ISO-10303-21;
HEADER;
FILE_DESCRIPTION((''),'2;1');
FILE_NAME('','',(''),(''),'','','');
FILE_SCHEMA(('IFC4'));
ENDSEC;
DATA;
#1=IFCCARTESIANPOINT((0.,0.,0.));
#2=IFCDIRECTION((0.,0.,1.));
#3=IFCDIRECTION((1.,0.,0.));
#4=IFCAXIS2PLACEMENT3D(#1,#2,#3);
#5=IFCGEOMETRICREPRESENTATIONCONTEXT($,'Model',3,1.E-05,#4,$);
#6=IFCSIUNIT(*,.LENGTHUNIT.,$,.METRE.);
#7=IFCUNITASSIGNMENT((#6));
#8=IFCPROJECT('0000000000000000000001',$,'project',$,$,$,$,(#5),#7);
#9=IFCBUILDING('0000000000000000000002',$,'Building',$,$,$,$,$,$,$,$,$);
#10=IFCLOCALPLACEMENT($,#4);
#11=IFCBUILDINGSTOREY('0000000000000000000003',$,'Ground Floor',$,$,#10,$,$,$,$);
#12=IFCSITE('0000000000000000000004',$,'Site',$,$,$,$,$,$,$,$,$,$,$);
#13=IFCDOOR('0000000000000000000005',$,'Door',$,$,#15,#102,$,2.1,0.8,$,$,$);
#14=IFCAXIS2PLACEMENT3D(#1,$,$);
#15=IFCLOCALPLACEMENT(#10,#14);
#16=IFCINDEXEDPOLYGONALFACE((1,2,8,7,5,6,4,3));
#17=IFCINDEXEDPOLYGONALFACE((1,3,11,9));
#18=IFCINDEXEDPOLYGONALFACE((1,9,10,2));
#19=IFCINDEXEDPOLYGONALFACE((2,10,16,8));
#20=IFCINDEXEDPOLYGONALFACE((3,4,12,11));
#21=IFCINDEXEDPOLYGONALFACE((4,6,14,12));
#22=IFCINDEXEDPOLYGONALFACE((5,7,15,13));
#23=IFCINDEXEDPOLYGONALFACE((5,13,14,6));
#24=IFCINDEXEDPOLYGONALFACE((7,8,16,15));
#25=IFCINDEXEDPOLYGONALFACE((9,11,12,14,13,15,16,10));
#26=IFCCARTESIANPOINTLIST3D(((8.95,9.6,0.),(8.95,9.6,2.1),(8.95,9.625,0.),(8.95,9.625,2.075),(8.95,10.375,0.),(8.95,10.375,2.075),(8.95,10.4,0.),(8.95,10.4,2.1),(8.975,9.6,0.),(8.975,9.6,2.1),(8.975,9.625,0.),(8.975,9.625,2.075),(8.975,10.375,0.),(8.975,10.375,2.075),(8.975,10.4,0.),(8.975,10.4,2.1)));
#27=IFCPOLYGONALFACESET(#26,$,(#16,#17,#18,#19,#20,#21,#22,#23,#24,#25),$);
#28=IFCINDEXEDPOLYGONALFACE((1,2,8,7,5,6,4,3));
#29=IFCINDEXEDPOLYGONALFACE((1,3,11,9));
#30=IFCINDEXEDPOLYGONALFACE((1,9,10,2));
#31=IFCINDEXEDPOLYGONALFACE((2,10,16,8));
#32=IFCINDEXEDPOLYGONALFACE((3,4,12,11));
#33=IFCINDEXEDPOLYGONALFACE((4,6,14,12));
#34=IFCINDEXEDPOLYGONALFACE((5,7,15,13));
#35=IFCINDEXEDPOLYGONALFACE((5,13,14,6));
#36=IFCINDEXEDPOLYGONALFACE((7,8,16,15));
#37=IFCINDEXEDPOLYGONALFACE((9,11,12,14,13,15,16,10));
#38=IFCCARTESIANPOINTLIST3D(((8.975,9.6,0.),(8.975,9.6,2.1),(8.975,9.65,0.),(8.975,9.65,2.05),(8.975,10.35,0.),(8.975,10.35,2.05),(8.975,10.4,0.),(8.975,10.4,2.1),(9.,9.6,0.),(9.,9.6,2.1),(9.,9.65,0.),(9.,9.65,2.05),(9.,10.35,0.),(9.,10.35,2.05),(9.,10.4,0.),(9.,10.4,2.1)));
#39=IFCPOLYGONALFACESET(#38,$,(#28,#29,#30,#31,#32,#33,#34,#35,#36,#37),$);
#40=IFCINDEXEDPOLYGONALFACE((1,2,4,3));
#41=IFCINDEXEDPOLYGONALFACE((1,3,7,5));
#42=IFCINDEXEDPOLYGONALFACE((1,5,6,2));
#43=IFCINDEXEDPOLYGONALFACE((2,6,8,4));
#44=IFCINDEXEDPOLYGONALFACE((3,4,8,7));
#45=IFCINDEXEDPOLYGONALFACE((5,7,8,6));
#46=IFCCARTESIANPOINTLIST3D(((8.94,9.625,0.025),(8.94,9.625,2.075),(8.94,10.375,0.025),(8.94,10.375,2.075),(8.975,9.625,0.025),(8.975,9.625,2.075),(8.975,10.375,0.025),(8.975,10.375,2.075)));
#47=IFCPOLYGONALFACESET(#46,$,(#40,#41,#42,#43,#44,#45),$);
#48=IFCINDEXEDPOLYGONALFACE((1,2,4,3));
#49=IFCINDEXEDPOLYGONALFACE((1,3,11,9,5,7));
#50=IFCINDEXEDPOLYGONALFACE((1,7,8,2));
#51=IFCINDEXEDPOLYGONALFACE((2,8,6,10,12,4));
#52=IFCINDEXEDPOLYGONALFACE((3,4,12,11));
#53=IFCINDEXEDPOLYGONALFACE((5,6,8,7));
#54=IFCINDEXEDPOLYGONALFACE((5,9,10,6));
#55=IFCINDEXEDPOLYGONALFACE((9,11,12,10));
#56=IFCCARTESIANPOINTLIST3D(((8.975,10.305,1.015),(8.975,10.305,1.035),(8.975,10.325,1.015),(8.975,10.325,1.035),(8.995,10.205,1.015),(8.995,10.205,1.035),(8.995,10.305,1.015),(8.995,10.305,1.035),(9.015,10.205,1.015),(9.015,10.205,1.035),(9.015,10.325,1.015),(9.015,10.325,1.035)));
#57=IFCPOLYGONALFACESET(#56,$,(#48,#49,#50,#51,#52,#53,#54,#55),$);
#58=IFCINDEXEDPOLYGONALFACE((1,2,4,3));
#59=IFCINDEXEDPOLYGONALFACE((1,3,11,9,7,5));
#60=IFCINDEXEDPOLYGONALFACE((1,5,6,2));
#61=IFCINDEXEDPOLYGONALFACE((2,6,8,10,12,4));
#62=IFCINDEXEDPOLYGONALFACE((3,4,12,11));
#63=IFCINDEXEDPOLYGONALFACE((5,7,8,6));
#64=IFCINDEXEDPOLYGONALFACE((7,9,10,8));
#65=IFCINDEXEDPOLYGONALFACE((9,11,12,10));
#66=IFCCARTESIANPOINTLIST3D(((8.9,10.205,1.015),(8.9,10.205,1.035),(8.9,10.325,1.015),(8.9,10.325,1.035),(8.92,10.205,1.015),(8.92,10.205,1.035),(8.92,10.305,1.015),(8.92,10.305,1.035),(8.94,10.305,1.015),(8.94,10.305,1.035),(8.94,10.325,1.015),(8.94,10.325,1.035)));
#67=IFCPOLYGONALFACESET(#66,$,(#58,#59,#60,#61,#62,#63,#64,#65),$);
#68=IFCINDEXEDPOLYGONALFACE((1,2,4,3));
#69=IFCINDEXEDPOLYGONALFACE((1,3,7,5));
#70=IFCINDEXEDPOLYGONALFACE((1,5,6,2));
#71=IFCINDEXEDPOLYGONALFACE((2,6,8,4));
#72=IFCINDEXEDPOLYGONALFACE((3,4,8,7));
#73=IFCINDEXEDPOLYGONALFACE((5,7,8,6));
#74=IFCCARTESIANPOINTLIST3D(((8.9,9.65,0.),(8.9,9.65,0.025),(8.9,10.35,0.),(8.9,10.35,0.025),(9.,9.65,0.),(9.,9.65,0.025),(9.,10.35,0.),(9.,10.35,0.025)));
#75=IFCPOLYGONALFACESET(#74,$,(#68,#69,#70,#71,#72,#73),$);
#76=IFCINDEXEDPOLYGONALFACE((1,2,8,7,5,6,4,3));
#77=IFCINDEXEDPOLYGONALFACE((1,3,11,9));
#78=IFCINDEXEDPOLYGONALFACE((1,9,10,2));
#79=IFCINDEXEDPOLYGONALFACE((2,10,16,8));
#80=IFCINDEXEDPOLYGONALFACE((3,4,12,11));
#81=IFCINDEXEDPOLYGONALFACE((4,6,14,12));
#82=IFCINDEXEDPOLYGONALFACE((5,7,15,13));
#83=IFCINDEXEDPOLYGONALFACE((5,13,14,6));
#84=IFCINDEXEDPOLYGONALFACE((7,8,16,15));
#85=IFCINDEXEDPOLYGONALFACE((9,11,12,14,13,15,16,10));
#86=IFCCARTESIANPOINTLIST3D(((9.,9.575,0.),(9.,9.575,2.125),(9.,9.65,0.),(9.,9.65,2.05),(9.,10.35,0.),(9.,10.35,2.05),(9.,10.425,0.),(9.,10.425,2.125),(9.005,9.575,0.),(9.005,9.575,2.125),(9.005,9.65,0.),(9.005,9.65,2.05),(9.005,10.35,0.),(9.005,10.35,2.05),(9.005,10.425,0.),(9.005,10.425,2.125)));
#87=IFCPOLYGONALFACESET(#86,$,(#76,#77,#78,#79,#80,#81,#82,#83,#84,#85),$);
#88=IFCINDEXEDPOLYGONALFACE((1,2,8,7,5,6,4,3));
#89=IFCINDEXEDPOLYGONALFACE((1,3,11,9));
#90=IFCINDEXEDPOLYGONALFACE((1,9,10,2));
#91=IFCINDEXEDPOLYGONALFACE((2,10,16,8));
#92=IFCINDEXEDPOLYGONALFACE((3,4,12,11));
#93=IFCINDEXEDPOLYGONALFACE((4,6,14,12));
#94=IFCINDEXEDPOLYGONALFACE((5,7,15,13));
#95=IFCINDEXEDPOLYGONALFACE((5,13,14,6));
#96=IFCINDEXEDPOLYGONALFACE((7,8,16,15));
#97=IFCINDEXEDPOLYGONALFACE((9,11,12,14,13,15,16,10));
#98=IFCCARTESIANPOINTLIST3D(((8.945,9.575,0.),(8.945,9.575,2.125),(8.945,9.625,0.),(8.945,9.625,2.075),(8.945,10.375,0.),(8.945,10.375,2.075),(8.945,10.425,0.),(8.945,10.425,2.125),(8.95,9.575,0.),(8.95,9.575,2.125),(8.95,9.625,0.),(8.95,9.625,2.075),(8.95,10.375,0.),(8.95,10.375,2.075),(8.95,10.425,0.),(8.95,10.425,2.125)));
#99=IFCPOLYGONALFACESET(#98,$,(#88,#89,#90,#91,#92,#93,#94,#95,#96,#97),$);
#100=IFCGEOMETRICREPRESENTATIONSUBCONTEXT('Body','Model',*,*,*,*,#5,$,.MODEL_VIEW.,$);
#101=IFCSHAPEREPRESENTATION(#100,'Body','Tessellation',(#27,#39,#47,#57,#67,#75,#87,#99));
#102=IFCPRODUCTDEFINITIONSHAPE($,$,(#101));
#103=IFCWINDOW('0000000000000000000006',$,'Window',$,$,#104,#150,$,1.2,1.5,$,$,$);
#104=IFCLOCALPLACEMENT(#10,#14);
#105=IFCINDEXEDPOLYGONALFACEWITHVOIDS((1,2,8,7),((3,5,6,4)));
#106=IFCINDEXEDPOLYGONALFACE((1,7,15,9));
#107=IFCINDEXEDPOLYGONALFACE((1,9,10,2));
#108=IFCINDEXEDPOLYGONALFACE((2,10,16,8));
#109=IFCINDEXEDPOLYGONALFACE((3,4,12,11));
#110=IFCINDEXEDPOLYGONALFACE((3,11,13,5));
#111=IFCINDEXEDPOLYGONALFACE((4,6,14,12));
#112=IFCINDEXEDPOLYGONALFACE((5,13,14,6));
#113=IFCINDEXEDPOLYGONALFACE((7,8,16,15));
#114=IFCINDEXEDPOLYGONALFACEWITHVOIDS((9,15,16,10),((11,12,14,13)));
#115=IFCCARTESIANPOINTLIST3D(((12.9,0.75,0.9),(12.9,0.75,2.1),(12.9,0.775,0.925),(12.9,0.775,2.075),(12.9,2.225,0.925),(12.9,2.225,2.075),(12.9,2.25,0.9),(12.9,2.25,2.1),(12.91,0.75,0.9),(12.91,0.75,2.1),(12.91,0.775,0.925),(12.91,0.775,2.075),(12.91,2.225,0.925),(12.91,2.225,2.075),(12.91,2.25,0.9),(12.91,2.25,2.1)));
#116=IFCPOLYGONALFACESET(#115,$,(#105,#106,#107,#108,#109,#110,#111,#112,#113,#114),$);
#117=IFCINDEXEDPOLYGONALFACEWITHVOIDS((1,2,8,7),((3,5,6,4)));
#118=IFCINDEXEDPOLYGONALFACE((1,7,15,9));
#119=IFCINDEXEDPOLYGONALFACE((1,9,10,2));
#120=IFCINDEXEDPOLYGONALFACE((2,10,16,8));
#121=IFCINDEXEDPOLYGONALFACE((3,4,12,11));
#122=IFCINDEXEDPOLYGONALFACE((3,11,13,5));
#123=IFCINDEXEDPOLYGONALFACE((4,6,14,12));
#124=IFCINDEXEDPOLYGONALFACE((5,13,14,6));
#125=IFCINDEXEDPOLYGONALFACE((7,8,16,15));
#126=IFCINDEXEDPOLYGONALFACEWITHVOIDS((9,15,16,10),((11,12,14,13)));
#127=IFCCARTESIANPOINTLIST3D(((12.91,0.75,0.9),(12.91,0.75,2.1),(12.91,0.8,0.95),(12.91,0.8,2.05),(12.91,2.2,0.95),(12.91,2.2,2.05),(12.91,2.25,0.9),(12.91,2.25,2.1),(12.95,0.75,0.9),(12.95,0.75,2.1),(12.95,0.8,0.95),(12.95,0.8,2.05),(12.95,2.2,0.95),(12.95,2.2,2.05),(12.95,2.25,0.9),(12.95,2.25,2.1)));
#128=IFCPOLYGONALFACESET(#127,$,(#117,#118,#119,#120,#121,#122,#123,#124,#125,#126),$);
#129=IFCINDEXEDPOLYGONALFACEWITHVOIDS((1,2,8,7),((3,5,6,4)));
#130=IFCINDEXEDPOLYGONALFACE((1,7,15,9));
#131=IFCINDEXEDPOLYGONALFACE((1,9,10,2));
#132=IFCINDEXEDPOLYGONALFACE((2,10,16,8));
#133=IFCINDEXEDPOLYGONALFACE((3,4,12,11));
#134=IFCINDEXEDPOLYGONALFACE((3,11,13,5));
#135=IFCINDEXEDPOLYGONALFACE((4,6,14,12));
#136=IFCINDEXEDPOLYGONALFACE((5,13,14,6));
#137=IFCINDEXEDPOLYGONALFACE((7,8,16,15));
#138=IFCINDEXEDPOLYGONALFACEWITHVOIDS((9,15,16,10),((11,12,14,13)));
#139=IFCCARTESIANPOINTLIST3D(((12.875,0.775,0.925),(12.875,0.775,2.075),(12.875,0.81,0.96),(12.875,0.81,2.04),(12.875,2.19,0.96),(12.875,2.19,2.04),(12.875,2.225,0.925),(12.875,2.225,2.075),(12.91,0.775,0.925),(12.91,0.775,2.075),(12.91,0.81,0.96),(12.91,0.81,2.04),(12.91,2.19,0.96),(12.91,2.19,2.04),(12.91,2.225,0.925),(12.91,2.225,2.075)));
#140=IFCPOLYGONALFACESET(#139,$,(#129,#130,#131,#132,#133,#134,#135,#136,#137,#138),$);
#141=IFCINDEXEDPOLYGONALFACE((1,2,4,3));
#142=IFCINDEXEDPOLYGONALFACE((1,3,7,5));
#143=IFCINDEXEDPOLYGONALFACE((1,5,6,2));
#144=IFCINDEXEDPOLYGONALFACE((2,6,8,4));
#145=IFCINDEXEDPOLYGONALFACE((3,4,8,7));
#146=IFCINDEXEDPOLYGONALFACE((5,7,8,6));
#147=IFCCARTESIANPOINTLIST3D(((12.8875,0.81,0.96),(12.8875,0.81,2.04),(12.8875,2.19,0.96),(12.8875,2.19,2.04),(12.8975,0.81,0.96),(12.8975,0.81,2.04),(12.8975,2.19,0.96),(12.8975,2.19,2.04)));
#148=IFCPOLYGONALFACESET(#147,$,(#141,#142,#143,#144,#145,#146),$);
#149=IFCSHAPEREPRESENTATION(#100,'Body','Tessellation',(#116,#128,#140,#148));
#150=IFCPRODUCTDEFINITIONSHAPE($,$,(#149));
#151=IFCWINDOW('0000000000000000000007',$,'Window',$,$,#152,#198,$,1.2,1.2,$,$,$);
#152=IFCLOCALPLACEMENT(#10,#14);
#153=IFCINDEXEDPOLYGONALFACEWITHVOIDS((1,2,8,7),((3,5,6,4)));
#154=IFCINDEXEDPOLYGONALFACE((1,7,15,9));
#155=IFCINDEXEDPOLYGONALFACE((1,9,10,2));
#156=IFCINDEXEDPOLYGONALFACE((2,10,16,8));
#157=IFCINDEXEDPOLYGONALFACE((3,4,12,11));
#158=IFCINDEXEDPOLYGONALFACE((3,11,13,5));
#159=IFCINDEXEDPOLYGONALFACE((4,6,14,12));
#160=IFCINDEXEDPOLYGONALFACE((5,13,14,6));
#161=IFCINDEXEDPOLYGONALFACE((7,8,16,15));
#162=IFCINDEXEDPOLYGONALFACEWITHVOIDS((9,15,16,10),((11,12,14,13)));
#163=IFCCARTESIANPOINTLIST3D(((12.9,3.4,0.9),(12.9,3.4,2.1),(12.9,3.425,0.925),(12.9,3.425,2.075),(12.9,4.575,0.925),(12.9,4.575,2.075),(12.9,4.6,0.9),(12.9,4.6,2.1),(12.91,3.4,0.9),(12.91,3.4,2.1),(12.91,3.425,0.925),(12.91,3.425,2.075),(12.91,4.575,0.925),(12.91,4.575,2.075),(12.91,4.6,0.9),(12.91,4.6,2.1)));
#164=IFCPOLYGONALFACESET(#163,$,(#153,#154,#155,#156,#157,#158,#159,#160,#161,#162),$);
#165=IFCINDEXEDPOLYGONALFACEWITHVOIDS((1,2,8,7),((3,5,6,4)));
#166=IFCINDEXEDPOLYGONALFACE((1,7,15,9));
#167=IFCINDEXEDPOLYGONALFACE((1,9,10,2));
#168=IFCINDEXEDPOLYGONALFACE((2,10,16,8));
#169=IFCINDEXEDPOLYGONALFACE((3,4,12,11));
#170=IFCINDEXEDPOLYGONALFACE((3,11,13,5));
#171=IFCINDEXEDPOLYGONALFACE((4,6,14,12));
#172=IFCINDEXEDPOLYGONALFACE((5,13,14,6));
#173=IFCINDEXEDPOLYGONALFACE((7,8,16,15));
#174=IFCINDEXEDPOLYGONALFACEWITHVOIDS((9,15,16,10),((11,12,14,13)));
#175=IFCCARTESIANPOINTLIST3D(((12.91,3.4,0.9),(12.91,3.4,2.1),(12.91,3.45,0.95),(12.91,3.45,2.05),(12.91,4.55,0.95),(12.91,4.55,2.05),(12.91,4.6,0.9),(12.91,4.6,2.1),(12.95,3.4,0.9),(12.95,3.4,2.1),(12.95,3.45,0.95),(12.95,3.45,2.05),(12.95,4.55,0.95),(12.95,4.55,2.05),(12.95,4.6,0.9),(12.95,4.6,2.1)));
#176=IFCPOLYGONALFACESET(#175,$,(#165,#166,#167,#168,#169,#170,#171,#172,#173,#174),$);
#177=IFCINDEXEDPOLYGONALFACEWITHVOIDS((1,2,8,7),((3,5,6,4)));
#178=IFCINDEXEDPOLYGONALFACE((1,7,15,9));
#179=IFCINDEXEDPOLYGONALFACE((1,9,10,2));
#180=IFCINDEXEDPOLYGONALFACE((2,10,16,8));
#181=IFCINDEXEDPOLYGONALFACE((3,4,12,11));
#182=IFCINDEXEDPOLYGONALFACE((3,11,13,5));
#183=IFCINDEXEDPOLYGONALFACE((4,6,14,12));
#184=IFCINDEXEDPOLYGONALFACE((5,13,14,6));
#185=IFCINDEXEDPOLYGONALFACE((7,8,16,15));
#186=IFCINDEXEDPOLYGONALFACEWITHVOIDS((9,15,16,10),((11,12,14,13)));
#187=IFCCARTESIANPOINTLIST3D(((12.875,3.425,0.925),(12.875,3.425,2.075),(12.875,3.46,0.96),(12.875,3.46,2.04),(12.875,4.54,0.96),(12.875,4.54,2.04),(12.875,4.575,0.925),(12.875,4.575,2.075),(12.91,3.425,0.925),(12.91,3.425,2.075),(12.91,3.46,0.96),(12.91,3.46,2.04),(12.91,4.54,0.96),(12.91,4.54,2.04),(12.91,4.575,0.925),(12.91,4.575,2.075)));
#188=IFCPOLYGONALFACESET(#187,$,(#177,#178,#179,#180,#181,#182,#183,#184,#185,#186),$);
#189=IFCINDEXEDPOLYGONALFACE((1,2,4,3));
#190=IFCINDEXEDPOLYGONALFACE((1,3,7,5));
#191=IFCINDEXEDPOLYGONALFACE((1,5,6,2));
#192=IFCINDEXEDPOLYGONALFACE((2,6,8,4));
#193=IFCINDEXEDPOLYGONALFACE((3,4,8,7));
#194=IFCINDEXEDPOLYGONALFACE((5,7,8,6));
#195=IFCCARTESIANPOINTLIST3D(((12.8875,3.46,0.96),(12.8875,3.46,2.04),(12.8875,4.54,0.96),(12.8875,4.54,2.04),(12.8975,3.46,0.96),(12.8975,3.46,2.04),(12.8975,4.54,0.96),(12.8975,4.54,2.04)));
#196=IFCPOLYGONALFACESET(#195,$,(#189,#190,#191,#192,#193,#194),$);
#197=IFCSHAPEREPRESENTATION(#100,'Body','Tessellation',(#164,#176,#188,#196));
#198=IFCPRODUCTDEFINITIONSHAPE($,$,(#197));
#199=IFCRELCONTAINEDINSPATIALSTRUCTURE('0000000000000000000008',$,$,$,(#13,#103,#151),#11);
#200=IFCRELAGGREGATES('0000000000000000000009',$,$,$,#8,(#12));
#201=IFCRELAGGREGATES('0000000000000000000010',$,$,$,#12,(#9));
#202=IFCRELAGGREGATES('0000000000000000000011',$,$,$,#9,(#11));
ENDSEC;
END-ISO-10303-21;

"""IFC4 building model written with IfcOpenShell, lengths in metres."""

from ifc_helpers import new_model, si_unit, frame, origin_with_axes, place, context, subcontext, project, spatial, line, indexed_curve, outline, extrude, element, save


model = new_model("IFC4")

# Units and contexts
model_context = context("Model", 3, precision=1e-05, world=origin_with_axes())
body_context = subcontext(model_context, "Body", "Model", "MODEL_VIEW")
ifc_project = project(units=[si_unit("LENGTHUNIT", "METRE")], contexts=[model_context])

# Site, building, storey
site = spatial("IfcSite", under=ifc_project, Name="Site")
building = spatial("IfcBuilding", under=site, Name="Building")
storey_placement = place(None, origin_with_axes())
storey = spatial("IfcBuildingStorey", under=building, at=storey_placement, Name="Ground Floor")

# Door
door_1_placement = place(storey_placement, frame((9.0, 9.6, 0.0), z_axis=(0.0, 0.0, 1.0), x_axis=(0.0, 1.0, 0.0)))
element("IfcDoor", 1, at=door_1_placement, inside=storey, Name="Door", OverallHeight=2.1, OverallWidth=0.8, context=body_context, shape_type="SweptSolid", body=[
    extrude(outline(indexed_curve([(0.0, 0.0), (0.0, 2.1), (0.8, 2.1), (0.8, 0.0), (0.775, 0.0), (0.775, 2.075), (0.025, 2.075), (0.025, 0.0)], segments=[line(1, 2, 3, 4, 5, 6, 7, 8, 1)])), frame((0.0, 0.025, 0.0), z_axis=(0.0, -1.0, 0.0), x_axis=(1.0, 0.0, 0.0)), (0.0, 0.0, -1.0), 0.025),
    extrude(outline(indexed_curve([(0.0, 0.0), (0.0, 2.1), (0.8, 2.1), (0.8, 0.0), (0.75, 0.0), (0.75, 2.05), (0.05, 2.05), (0.05, 0.0)], segments=[line(1, 2, 3, 4, 5, 6, 7, 8, 1)])), frame((0.0, 0.0, 0.0), z_axis=(0.0, -1.0, 0.0), x_axis=(1.0, 0.0, 0.0)), (0.0, 0.0, -1.0), 0.025),
    extrude(outline(indexed_curve([(0.0, 0.0), (0.75, 0.0), (0.75, 0.035), (0.0, 0.035)], segments=[line(1, 2, 3, 4, 1)])), frame((0.025, 0.025, 0.025), z_axis=(0.0, 0.0, 1.0), x_axis=(1.0, 0.0, 0.0)), (0.0, 0.0, 1.0), 2.05),
    extrude(outline(indexed_curve([(0.0, 0.0), (0.0, -0.04), (-0.12, -0.04), (-0.12, -0.02), (-0.02, -0.02), (-0.02, 0.0)], segments=[line(1, 2, 3, 4, 5, 6, 1)])), frame((0.725, 0.025, 1.015), z_axis=(0.0, 0.0, 1.0), x_axis=(1.0, 0.0, 0.0)), (0.0, 0.0, 1.0), 0.02),
    extrude(outline(indexed_curve([(0.0, 0.0), (0.0, 0.04), (-0.12, 0.04), (-0.12, 0.02), (-0.02, 0.02), (-0.02, 0.0)], segments=[line(1, 2, 3, 4, 5, 6, 1)])), frame((0.725, 0.06, 1.015), z_axis=(0.0, 0.0, 1.0), x_axis=(1.0, 0.0, 0.0)), (0.0, 0.0, 1.0), 0.02),
    extrude(outline(indexed_curve([(0.0, 0.0), (0.7, 0.0), (0.7, 0.1), (0.0, 0.1)], segments=[line(1, 2, 3, 4, 1)])), frame((0.05, 0.0, 0.0), z_axis=(0.0, 0.0, 1.0), x_axis=(1.0, 0.0, 0.0)), (0.0, 0.0, 1.0), 0.025),
    extrude(outline(indexed_curve([(0.0, 0.0), (0.0, 2.125), (0.85, 2.125), (0.85, 0.0), (0.775, 0.0), (0.775, 2.05), (0.075, 2.05), (0.075, 0.0)], segments=[line(1, 2, 3, 4, 5, 6, 7, 8, 1)])), frame((-0.025, -0.005, 0.0), z_axis=(0.0, -1.0, 0.0), x_axis=(1.0, 0.0, 0.0)), (0.0, 0.0, -1.0), 0.005),
    extrude(outline(indexed_curve([(0.0, 0.0), (0.0, 2.125), (0.85, 2.125), (0.85, 0.0), (0.8, 0.0), (0.8, 2.075), (0.05, 2.075), (0.05, 0.0)], segments=[line(1, 2, 3, 4, 5, 6, 7, 8, 1)])), frame((-0.025, 0.05, 0.0), z_axis=(0.0, -1.0, 0.0), x_axis=(1.0, 0.0, 0.0)), (0.0, 0.0, -1.0), 0.005),
])

# Windows
window_1_placement = place(storey_placement, frame((13.0, 0.75, 0.9), z_axis=(0.0, 0.0, 1.0), x_axis=(0.0, 1.0, 0.0)))
element("IfcWindow", 2, at=window_1_placement, inside=storey, Name="Window", OverallHeight=1.2, OverallWidth=1.5, context=body_context, shape_type="SweptSolid", body=[
    extrude(outline(indexed_curve([(0.0, 0.0), (1.5, 0.0), (1.5, 1.2), (0.0, 1.2)], segments=[line(1, 2, 3, 4, 1)]), holes=[indexed_curve([(0.025, 0.025), (1.475, 0.025), (1.475, 1.175), (0.025, 1.175)], segments=[line(1, 2, 3, 4, 1)])]), frame((0.0, 0.09, 0.0), z_axis=(0.0, -1.0, 0.0), x_axis=(1.0, 0.0, 0.0)), (0.0, 0.0, -1.0), 0.01),
    extrude(outline(indexed_curve([(0.0, 0.0), (1.5, 0.0), (1.5, 1.2), (0.0, 1.2)], segments=[line(1, 2, 3, 4, 1)]), holes=[indexed_curve([(0.05, 0.05), (1.45, 0.05), (1.45, 1.15), (0.05, 1.15)], segments=[line(1, 2, 3, 4, 1)])]), frame((0.0, 0.05, 0.0), z_axis=(0.0, -1.0, 0.0), x_axis=(1.0, 0.0, 0.0)), (0.0, 0.0, -1.0), 0.04),
    extrude(outline(indexed_curve([(0.0, 0.0), (1.45, 0.0), (1.45, 1.15), (0.0, 1.15)], segments=[line(1, 2, 3, 4, 1)]), holes=[indexed_curve([(0.035, 0.035), (1.415, 0.035), (1.415, 1.115), (0.035, 1.115)], segments=[line(1, 2, 3, 4, 1)])]), frame((0.025, 0.09, 0.025), z_axis=(0.0, -1.0, 0.0), x_axis=(1.0, 0.0, 0.0)), (0.0, 0.0, -1.0), 0.035),
    extrude(outline(indexed_curve([(0.035, 0.035), (1.415, 0.035), (1.415, 1.115), (0.035, 1.115)], segments=[line(1, 2, 3, 4, 1)])), frame((0.025, 0.1025, 0.025), z_axis=(0.0, -1.0, 0.0), x_axis=(1.0, 0.0, 0.0)), (0.0, 0.0, -1.0), 0.01),
])
window_2_placement = place(storey_placement, frame((13.0, 3.4, 0.9), z_axis=(0.0, 0.0, 1.0), x_axis=(0.0, 1.0, 0.0)))
element("IfcWindow", 3, at=window_2_placement, inside=storey, Name="Window", OverallHeight=1.2, OverallWidth=1.2, context=body_context, shape_type="SweptSolid", body=[
    extrude(outline(indexed_curve([(0.0, 0.0), (1.2, 0.0), (1.2, 1.2), (0.0, 1.2)], segments=[line(1, 2, 3, 4, 1)]), holes=[indexed_curve([(0.025, 0.025), (1.175, 0.025), (1.175, 1.175), (0.025, 1.175)], segments=[line(1, 2, 3, 4, 1)])]), frame((0.0, 0.09, 0.0), z_axis=(0.0, -1.0, 0.0), x_axis=(1.0, 0.0, 0.0)), (0.0, 0.0, -1.0), 0.01),
    extrude(outline(indexed_curve([(0.0, 0.0), (1.2, 0.0), (1.2, 1.2), (0.0, 1.2)], segments=[line(1, 2, 3, 4, 1)]), holes=[indexed_curve([(0.05, 0.05), (1.15, 0.05), (1.15, 1.15), (0.05, 1.15)], segments=[line(1, 2, 3, 4, 1)])]), frame((0.0, 0.05, 0.0), z_axis=(0.0, -1.0, 0.0), x_axis=(1.0, 0.0, 0.0)), (0.0, 0.0, -1.0), 0.04),
    extrude(outline(indexed_curve([(0.0, 0.0), (1.15, 0.0), (1.15, 1.15), (0.0, 1.15)], segments=[line(1, 2, 3, 4, 1)]), holes=[indexed_curve([(0.035, 0.035), (1.115, 0.035), (1.115, 1.115), (0.035, 1.115)], segments=[line(1, 2, 3, 4, 1)])]), frame((0.025, 0.09, 0.025), z_axis=(0.0, -1.0, 0.0), x_axis=(1.0, 0.0, 0.0)), (0.0, 0.0, -1.0), 0.035),
    extrude(outline(indexed_curve([(0.035, 0.035), (1.115, 0.035), (1.115, 1.115), (0.035, 1.115)], segments=[line(1, 2, 3, 4, 1)])), frame((0.025, 0.1025, 0.025), z_axis=(0.0, -1.0, 0.0), x_axis=(1.0, 0.0, 0.0)), (0.0, 0.0, -1.0), 0.01),
])

save(model, "model.ifc")
